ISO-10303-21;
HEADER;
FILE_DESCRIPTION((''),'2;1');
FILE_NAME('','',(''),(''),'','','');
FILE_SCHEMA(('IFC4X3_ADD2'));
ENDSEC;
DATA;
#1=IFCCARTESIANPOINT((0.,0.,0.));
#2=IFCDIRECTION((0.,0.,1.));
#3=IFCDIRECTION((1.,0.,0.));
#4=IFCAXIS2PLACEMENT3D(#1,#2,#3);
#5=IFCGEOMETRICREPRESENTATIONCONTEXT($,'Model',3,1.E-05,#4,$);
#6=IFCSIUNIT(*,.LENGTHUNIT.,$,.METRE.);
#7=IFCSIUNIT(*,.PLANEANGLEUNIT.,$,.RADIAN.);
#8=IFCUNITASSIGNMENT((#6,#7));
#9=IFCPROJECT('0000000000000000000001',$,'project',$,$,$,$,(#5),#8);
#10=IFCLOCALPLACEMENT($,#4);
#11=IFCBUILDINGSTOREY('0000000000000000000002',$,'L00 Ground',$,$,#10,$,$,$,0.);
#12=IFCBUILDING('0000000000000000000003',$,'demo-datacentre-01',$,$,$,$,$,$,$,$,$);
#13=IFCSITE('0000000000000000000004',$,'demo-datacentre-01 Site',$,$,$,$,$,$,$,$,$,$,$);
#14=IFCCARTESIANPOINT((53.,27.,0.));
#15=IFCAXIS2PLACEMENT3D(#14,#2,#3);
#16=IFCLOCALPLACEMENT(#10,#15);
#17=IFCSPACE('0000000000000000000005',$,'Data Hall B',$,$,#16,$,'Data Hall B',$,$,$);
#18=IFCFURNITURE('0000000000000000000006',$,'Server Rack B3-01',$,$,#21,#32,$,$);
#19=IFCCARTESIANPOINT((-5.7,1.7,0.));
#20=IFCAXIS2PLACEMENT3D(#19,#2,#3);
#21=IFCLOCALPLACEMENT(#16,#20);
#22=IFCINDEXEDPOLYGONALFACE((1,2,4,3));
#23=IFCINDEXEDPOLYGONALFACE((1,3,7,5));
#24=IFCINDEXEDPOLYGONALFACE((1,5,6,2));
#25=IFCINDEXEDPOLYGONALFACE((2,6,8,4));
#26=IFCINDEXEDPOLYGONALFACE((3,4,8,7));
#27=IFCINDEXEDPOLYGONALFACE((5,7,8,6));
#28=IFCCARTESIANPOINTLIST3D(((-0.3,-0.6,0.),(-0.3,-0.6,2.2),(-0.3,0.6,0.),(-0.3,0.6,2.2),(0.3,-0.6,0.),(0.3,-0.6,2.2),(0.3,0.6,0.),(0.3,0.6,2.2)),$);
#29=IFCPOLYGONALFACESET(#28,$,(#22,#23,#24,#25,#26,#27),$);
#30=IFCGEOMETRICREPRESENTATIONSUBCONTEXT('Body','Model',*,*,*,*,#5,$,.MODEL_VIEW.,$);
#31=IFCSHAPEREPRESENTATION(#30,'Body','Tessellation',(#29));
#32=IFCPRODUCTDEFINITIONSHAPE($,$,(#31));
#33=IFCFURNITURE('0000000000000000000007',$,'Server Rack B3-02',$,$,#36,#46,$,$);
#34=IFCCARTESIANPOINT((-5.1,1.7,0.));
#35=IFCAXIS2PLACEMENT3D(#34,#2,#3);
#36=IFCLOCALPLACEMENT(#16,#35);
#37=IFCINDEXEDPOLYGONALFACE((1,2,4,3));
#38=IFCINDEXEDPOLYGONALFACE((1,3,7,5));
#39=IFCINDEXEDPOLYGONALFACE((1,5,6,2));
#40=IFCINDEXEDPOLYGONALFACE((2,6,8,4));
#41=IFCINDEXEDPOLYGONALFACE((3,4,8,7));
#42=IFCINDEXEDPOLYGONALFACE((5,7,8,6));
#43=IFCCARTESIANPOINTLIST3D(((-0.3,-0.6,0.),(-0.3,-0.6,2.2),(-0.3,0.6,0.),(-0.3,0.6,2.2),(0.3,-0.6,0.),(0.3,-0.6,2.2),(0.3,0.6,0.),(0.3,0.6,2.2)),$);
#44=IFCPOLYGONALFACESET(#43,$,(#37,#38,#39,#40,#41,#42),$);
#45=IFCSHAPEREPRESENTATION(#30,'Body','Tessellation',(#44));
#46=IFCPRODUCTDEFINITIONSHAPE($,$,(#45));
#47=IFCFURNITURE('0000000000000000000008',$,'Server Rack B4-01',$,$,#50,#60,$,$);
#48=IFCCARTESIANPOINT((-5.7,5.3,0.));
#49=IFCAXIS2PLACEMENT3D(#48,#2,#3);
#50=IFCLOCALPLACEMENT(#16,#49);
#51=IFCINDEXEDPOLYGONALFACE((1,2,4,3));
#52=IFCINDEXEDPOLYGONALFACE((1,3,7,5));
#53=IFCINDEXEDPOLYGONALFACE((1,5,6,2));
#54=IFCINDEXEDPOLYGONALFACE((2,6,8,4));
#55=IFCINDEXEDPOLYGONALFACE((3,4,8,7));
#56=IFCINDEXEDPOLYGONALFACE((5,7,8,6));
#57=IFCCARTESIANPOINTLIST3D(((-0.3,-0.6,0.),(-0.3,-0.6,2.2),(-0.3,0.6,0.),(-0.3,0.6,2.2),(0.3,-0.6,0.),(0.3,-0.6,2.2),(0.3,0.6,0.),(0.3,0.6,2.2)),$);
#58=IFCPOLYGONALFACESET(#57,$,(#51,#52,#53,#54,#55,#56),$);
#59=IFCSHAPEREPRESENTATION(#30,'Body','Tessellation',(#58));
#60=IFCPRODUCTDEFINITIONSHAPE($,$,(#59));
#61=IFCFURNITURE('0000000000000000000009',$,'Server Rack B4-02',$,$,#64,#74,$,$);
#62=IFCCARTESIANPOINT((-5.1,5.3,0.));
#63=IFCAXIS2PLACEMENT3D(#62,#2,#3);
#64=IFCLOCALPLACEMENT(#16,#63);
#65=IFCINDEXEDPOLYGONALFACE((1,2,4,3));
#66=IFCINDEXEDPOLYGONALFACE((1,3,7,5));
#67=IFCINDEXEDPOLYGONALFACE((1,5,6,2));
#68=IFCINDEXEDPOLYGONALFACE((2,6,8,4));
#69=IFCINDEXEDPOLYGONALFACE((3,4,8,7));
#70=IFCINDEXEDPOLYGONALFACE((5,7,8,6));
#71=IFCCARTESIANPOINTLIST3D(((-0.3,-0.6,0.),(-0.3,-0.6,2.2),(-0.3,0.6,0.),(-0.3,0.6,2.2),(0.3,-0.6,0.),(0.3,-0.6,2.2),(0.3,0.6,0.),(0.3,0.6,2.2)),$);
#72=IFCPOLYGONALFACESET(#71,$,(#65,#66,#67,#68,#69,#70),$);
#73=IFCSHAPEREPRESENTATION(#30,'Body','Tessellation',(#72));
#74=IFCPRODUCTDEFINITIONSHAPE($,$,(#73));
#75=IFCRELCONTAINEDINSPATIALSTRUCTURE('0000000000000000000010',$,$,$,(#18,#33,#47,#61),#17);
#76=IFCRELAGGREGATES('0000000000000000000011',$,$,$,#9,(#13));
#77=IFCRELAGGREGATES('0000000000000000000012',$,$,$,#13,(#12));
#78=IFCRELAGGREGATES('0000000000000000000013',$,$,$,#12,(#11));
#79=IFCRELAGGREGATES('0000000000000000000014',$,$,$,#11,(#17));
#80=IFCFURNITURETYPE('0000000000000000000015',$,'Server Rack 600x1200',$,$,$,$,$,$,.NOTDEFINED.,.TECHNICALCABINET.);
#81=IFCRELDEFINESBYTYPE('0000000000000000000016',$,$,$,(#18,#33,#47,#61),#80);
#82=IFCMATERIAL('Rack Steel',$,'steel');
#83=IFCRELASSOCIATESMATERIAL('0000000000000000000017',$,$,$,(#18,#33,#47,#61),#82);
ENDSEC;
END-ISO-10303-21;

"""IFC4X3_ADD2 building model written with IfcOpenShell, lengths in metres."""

from ifc_helpers import new_model, si_unit, frame, origin_with_axes, place, context, subcontext, project, spatial, rectangle, extrude, material, type_object, element, save


model = new_model("IFC4X3_ADD2")

# Units and contexts
model_context = context("Model", 3, precision=1e-05, world=origin_with_axes())
body_context = subcontext(model_context, "Body", "Model", "MODEL_VIEW")
ifc_project = project(units=[si_unit("LENGTHUNIT", "METRE"), si_unit("PLANEANGLEUNIT", "RADIAN")], contexts=[model_context])

# Site, building, storey
site = spatial("IfcSite", under=ifc_project, Name="demo-datacentre-01 Site")
building = spatial("IfcBuilding", under=site, Name="demo-datacentre-01")
storey_placement = place(None, origin_with_axes())
storey = spatial("IfcBuildingStorey", under=building, at=storey_placement, Name="L00 Ground", Elevation=0.0)

# Shared definitions
space_placement = place(storey_placement, frame((53.0, 27.0, 0.0), z_axis=(0.0, 0.0, 1.0), x_axis=(1.0, 0.0, 0.0)))
space = spatial("IfcSpace", under=storey, at=space_placement, Name="Data Hall B", LongName="Data Hall B")

# Furniture
ifc_material_1 = material(Name="Rack Steel", Category="steel")
furniture_type = type_object("IfcFurnitureType", Name="Server Rack 600x1200", AssemblyPlace="NOTDEFINED", PredefinedType="TECHNICALCABINET")
for number, where, z_axis, x_axis, name in (
    (1, (-5.7, 1.7, 0.0), (0.0, 0.0, 1.0), (1.0, 0.0, 0.0), "Server Rack B3-01"),
    (2, (-5.1, 1.7, 0.0), (0.0, 0.0, 1.0), (1.0, 0.0, 0.0), "Server Rack B3-02"),
    (3, (-5.7, 5.3, 0.0), (0.0, 0.0, 1.0), (1.0, 0.0, 0.0), "Server Rack B4-01"),
    (4, (-5.1, 5.3, 0.0), (0.0, 0.0, 1.0), (1.0, 0.0, 0.0), "Server Rack B4-02"),
):
    element("IfcFurniture", number, at=place(space_placement, frame(where, z_axis=z_axis, x_axis=x_axis)), inside=space, type_object=furniture_type, material=ifc_material_1, Name=name, context=body_context, shape_type="SweptSolid", body=[
        extrude(rectangle(XDim=0.6, YDim=1.2), origin_with_axes(), (0.0, 0.0, 1.0), 2.2),
    ])

save(model, "model.ifc")
